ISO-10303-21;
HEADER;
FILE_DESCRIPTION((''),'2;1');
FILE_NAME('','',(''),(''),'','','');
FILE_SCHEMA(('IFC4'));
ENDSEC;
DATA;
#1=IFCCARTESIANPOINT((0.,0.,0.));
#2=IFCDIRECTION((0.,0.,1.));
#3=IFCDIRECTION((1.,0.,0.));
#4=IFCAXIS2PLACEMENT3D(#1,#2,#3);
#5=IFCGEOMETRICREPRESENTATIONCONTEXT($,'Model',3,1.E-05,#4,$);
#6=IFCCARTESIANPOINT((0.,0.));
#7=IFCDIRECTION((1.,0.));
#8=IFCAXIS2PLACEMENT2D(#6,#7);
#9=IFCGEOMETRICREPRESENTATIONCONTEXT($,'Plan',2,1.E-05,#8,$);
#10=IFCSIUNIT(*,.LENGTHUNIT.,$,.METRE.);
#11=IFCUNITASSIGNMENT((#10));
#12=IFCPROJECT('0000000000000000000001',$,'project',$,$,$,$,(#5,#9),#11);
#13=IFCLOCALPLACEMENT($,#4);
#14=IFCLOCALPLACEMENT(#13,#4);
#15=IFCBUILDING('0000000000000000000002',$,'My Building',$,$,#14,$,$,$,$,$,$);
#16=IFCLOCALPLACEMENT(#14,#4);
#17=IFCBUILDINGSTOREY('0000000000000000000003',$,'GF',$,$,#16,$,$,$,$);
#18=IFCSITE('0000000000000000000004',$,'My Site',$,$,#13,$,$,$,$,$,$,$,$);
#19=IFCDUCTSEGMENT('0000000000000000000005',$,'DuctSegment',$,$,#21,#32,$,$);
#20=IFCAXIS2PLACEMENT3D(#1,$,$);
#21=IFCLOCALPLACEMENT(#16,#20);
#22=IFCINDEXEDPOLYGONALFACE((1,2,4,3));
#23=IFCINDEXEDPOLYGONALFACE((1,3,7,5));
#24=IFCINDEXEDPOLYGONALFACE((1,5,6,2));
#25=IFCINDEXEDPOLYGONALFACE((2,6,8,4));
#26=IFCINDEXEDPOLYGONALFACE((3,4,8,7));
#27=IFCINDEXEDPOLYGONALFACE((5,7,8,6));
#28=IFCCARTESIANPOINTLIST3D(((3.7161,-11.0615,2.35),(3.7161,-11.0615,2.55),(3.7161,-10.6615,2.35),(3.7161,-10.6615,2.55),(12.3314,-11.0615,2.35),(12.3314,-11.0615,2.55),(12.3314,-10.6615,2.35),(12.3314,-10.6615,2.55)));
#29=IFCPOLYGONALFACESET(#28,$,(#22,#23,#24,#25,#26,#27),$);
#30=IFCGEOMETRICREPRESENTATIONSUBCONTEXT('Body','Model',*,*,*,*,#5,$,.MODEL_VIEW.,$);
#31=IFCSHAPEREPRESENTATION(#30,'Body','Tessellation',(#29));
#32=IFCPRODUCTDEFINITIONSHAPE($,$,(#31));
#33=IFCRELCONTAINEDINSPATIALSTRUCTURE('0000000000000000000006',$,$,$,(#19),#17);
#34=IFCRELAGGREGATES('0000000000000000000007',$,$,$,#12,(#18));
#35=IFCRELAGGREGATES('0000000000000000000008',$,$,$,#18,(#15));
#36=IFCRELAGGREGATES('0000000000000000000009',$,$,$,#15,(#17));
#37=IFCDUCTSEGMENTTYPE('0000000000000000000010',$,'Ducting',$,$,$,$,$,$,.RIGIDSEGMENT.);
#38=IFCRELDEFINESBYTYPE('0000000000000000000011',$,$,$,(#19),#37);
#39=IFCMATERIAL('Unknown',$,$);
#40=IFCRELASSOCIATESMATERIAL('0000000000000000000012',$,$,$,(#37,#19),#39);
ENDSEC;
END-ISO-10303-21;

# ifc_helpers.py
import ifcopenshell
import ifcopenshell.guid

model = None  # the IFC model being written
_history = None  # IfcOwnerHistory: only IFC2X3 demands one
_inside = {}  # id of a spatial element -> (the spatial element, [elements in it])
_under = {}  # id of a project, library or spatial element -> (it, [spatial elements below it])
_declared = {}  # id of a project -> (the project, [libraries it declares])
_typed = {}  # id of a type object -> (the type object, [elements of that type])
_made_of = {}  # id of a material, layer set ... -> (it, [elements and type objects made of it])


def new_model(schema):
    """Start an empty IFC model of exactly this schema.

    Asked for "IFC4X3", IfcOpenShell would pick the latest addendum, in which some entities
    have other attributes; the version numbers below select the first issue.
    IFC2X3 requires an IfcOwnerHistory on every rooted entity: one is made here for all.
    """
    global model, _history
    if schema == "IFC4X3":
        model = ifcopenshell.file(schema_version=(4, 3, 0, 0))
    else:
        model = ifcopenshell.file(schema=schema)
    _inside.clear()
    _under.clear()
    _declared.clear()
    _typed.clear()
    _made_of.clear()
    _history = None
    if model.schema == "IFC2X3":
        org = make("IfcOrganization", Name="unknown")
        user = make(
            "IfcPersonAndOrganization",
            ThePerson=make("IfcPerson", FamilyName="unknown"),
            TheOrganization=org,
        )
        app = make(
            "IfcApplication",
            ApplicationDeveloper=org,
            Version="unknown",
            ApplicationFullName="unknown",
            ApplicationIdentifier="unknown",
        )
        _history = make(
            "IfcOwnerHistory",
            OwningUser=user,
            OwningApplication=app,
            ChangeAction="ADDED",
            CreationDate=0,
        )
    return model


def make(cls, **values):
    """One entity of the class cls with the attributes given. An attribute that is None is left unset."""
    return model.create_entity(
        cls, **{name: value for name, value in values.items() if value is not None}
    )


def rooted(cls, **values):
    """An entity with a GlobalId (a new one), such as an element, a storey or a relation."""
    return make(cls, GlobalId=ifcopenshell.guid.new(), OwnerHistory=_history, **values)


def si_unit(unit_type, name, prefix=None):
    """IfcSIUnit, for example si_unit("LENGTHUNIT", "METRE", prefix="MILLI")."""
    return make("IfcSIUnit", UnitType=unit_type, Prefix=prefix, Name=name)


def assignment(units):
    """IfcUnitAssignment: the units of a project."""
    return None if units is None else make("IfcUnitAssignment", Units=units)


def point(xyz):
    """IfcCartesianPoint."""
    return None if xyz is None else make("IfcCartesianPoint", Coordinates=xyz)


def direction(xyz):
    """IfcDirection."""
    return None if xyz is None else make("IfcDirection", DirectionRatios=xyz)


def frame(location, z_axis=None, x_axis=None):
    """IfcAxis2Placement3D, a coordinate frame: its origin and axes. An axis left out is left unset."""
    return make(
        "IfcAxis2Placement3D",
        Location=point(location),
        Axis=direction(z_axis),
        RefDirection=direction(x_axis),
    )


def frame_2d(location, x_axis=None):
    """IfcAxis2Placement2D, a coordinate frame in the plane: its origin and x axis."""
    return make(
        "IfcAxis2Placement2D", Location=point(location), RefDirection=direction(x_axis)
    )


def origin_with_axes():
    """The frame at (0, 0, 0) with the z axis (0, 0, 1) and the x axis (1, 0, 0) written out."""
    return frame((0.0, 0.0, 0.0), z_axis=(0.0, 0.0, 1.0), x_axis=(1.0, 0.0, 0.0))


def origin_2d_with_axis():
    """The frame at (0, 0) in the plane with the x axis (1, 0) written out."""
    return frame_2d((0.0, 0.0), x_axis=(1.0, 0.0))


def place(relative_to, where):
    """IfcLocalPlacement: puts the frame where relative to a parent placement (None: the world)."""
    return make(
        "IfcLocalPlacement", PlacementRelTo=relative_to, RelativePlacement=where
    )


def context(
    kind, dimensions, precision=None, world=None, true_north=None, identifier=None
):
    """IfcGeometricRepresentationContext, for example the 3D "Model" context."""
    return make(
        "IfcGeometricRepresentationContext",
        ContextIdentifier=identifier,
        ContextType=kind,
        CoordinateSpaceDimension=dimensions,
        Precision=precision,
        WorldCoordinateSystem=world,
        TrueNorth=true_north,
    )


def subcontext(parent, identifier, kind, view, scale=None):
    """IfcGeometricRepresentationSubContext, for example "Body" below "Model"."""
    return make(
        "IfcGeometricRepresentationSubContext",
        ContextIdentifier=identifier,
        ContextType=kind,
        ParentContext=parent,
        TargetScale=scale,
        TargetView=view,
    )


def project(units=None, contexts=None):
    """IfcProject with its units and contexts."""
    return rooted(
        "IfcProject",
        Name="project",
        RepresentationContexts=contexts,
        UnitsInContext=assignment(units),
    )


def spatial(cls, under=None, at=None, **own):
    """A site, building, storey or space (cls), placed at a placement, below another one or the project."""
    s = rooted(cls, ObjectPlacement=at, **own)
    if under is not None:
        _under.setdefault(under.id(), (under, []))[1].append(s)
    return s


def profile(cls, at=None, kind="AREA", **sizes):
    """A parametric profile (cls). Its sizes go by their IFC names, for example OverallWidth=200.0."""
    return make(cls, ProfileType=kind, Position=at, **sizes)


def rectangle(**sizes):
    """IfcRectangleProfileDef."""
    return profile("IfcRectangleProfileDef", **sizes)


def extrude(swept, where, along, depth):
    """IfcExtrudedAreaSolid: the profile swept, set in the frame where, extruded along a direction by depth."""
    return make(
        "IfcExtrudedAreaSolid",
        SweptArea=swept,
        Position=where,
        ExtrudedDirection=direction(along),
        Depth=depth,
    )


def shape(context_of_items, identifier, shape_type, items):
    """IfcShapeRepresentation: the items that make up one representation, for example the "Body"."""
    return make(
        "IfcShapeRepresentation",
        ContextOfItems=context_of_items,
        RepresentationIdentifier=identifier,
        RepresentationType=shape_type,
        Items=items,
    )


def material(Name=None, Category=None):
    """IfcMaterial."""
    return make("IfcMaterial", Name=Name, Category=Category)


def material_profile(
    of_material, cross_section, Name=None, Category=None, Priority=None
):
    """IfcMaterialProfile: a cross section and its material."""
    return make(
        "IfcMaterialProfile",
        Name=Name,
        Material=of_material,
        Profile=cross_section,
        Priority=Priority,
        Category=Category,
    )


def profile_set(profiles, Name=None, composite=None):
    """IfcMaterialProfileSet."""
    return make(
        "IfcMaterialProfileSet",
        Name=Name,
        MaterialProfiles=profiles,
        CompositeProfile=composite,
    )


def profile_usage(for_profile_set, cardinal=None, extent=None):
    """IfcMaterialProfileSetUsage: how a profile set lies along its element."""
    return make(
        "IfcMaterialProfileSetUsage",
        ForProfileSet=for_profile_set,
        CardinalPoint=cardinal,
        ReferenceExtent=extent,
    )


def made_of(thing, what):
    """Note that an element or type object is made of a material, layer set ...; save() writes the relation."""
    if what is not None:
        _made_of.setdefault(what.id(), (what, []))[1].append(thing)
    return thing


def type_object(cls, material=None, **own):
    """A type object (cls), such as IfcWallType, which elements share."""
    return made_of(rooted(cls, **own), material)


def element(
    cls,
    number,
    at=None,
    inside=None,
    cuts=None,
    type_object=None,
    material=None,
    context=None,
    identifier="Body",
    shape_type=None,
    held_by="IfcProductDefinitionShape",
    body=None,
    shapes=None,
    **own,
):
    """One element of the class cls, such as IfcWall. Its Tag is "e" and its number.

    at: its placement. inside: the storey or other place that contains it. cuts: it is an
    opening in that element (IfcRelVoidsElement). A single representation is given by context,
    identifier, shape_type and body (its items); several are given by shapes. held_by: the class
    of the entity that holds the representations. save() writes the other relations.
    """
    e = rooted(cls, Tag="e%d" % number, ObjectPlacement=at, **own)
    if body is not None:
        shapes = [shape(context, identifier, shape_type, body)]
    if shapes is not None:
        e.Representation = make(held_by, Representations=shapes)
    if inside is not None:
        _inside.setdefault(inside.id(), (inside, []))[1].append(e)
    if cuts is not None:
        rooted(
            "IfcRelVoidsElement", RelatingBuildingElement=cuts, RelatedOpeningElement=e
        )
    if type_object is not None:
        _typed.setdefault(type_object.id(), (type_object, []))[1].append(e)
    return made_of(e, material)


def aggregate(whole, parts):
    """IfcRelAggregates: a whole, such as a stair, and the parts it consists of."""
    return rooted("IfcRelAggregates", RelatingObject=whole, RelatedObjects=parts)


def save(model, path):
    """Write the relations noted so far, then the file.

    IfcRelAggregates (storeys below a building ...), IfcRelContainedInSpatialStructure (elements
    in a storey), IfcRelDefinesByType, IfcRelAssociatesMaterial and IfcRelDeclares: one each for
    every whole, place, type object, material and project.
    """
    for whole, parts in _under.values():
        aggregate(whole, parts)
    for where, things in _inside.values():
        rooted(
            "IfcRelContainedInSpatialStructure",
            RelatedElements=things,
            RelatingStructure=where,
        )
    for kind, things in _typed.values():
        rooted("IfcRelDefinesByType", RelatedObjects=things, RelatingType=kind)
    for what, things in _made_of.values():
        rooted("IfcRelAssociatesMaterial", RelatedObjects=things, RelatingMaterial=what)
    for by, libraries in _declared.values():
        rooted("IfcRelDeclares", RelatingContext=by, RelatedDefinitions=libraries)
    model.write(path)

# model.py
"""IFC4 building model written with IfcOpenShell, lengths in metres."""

from ifc_helpers import new_model, si_unit, frame, origin_with_axes, origin_2d_with_axis, place, context, subcontext, project, spatial, rectangle, extrude, material, material_profile, profile_set, profile_usage, type_object, element, save


model = new_model("IFC4")

# Units and contexts
model_context = context("Model", 3, precision=1e-05, world=origin_with_axes())
plan_context = context("Plan", 2, precision=1e-05, world=origin_2d_with_axis())
body_context_1 = subcontext(model_context, "Body", "Model", "MODEL_VIEW")
ifc_project = project(units=[si_unit("LENGTHUNIT", "METRE")], contexts=[model_context, plan_context])

# Site, building, storey
site_placement = place(None, origin_with_axes())
site = spatial("IfcSite", under=ifc_project, at=site_placement, Name="My Site")
building_placement = place(site_placement, origin_with_axes())
building = spatial("IfcBuilding", under=site, at=building_placement, Name="My Building")
storey_placement = place(building_placement, origin_with_axes())
storey = spatial("IfcBuildingStorey", under=building, at=storey_placement, Name="GF")

# Shared definitions
ifc_material_1 = material(Name="Unknown")

# Duct segment
ifc_material_profile_1 = material_profile(ifc_material_1, rectangle(XDim=0.4, YDim=0.2))
ifc_profile_set_1 = profile_set([ifc_material_profile_1])
ifc_profile_usage_1 = profile_usage(ifc_profile_set_1, cardinal=4)
duct_segment_type = type_object("IfcDuctSegmentType", Name="Ducting", PredefinedType="RIGIDSEGMENT", material=ifc_profile_set_1)
duct_segment_placement = place(storey_placement, frame((12.3314, -11.0615, 2.45), z_axis=(-1.0, 0.0, 0.0), x_axis=(0.0, -1.0, 0.0)))
element("IfcDuctSegment", 1, at=duct_segment_placement, inside=storey, type_object=duct_segment_type, material=ifc_profile_usage_1, Name="DuctSegment", context=body_context_1, shape_type="SweptSolid", body=[
    extrude(rectangle(XDim=0.4, YDim=0.2), frame((-0.2, 0.0, 0.0), z_axis=(0.0, 0.0, 1.0), x_axis=(1.0, 0.0, 0.0)), (0.0, 0.0, 1.0), 8.6153),
])

save(model, "model.ifc")
